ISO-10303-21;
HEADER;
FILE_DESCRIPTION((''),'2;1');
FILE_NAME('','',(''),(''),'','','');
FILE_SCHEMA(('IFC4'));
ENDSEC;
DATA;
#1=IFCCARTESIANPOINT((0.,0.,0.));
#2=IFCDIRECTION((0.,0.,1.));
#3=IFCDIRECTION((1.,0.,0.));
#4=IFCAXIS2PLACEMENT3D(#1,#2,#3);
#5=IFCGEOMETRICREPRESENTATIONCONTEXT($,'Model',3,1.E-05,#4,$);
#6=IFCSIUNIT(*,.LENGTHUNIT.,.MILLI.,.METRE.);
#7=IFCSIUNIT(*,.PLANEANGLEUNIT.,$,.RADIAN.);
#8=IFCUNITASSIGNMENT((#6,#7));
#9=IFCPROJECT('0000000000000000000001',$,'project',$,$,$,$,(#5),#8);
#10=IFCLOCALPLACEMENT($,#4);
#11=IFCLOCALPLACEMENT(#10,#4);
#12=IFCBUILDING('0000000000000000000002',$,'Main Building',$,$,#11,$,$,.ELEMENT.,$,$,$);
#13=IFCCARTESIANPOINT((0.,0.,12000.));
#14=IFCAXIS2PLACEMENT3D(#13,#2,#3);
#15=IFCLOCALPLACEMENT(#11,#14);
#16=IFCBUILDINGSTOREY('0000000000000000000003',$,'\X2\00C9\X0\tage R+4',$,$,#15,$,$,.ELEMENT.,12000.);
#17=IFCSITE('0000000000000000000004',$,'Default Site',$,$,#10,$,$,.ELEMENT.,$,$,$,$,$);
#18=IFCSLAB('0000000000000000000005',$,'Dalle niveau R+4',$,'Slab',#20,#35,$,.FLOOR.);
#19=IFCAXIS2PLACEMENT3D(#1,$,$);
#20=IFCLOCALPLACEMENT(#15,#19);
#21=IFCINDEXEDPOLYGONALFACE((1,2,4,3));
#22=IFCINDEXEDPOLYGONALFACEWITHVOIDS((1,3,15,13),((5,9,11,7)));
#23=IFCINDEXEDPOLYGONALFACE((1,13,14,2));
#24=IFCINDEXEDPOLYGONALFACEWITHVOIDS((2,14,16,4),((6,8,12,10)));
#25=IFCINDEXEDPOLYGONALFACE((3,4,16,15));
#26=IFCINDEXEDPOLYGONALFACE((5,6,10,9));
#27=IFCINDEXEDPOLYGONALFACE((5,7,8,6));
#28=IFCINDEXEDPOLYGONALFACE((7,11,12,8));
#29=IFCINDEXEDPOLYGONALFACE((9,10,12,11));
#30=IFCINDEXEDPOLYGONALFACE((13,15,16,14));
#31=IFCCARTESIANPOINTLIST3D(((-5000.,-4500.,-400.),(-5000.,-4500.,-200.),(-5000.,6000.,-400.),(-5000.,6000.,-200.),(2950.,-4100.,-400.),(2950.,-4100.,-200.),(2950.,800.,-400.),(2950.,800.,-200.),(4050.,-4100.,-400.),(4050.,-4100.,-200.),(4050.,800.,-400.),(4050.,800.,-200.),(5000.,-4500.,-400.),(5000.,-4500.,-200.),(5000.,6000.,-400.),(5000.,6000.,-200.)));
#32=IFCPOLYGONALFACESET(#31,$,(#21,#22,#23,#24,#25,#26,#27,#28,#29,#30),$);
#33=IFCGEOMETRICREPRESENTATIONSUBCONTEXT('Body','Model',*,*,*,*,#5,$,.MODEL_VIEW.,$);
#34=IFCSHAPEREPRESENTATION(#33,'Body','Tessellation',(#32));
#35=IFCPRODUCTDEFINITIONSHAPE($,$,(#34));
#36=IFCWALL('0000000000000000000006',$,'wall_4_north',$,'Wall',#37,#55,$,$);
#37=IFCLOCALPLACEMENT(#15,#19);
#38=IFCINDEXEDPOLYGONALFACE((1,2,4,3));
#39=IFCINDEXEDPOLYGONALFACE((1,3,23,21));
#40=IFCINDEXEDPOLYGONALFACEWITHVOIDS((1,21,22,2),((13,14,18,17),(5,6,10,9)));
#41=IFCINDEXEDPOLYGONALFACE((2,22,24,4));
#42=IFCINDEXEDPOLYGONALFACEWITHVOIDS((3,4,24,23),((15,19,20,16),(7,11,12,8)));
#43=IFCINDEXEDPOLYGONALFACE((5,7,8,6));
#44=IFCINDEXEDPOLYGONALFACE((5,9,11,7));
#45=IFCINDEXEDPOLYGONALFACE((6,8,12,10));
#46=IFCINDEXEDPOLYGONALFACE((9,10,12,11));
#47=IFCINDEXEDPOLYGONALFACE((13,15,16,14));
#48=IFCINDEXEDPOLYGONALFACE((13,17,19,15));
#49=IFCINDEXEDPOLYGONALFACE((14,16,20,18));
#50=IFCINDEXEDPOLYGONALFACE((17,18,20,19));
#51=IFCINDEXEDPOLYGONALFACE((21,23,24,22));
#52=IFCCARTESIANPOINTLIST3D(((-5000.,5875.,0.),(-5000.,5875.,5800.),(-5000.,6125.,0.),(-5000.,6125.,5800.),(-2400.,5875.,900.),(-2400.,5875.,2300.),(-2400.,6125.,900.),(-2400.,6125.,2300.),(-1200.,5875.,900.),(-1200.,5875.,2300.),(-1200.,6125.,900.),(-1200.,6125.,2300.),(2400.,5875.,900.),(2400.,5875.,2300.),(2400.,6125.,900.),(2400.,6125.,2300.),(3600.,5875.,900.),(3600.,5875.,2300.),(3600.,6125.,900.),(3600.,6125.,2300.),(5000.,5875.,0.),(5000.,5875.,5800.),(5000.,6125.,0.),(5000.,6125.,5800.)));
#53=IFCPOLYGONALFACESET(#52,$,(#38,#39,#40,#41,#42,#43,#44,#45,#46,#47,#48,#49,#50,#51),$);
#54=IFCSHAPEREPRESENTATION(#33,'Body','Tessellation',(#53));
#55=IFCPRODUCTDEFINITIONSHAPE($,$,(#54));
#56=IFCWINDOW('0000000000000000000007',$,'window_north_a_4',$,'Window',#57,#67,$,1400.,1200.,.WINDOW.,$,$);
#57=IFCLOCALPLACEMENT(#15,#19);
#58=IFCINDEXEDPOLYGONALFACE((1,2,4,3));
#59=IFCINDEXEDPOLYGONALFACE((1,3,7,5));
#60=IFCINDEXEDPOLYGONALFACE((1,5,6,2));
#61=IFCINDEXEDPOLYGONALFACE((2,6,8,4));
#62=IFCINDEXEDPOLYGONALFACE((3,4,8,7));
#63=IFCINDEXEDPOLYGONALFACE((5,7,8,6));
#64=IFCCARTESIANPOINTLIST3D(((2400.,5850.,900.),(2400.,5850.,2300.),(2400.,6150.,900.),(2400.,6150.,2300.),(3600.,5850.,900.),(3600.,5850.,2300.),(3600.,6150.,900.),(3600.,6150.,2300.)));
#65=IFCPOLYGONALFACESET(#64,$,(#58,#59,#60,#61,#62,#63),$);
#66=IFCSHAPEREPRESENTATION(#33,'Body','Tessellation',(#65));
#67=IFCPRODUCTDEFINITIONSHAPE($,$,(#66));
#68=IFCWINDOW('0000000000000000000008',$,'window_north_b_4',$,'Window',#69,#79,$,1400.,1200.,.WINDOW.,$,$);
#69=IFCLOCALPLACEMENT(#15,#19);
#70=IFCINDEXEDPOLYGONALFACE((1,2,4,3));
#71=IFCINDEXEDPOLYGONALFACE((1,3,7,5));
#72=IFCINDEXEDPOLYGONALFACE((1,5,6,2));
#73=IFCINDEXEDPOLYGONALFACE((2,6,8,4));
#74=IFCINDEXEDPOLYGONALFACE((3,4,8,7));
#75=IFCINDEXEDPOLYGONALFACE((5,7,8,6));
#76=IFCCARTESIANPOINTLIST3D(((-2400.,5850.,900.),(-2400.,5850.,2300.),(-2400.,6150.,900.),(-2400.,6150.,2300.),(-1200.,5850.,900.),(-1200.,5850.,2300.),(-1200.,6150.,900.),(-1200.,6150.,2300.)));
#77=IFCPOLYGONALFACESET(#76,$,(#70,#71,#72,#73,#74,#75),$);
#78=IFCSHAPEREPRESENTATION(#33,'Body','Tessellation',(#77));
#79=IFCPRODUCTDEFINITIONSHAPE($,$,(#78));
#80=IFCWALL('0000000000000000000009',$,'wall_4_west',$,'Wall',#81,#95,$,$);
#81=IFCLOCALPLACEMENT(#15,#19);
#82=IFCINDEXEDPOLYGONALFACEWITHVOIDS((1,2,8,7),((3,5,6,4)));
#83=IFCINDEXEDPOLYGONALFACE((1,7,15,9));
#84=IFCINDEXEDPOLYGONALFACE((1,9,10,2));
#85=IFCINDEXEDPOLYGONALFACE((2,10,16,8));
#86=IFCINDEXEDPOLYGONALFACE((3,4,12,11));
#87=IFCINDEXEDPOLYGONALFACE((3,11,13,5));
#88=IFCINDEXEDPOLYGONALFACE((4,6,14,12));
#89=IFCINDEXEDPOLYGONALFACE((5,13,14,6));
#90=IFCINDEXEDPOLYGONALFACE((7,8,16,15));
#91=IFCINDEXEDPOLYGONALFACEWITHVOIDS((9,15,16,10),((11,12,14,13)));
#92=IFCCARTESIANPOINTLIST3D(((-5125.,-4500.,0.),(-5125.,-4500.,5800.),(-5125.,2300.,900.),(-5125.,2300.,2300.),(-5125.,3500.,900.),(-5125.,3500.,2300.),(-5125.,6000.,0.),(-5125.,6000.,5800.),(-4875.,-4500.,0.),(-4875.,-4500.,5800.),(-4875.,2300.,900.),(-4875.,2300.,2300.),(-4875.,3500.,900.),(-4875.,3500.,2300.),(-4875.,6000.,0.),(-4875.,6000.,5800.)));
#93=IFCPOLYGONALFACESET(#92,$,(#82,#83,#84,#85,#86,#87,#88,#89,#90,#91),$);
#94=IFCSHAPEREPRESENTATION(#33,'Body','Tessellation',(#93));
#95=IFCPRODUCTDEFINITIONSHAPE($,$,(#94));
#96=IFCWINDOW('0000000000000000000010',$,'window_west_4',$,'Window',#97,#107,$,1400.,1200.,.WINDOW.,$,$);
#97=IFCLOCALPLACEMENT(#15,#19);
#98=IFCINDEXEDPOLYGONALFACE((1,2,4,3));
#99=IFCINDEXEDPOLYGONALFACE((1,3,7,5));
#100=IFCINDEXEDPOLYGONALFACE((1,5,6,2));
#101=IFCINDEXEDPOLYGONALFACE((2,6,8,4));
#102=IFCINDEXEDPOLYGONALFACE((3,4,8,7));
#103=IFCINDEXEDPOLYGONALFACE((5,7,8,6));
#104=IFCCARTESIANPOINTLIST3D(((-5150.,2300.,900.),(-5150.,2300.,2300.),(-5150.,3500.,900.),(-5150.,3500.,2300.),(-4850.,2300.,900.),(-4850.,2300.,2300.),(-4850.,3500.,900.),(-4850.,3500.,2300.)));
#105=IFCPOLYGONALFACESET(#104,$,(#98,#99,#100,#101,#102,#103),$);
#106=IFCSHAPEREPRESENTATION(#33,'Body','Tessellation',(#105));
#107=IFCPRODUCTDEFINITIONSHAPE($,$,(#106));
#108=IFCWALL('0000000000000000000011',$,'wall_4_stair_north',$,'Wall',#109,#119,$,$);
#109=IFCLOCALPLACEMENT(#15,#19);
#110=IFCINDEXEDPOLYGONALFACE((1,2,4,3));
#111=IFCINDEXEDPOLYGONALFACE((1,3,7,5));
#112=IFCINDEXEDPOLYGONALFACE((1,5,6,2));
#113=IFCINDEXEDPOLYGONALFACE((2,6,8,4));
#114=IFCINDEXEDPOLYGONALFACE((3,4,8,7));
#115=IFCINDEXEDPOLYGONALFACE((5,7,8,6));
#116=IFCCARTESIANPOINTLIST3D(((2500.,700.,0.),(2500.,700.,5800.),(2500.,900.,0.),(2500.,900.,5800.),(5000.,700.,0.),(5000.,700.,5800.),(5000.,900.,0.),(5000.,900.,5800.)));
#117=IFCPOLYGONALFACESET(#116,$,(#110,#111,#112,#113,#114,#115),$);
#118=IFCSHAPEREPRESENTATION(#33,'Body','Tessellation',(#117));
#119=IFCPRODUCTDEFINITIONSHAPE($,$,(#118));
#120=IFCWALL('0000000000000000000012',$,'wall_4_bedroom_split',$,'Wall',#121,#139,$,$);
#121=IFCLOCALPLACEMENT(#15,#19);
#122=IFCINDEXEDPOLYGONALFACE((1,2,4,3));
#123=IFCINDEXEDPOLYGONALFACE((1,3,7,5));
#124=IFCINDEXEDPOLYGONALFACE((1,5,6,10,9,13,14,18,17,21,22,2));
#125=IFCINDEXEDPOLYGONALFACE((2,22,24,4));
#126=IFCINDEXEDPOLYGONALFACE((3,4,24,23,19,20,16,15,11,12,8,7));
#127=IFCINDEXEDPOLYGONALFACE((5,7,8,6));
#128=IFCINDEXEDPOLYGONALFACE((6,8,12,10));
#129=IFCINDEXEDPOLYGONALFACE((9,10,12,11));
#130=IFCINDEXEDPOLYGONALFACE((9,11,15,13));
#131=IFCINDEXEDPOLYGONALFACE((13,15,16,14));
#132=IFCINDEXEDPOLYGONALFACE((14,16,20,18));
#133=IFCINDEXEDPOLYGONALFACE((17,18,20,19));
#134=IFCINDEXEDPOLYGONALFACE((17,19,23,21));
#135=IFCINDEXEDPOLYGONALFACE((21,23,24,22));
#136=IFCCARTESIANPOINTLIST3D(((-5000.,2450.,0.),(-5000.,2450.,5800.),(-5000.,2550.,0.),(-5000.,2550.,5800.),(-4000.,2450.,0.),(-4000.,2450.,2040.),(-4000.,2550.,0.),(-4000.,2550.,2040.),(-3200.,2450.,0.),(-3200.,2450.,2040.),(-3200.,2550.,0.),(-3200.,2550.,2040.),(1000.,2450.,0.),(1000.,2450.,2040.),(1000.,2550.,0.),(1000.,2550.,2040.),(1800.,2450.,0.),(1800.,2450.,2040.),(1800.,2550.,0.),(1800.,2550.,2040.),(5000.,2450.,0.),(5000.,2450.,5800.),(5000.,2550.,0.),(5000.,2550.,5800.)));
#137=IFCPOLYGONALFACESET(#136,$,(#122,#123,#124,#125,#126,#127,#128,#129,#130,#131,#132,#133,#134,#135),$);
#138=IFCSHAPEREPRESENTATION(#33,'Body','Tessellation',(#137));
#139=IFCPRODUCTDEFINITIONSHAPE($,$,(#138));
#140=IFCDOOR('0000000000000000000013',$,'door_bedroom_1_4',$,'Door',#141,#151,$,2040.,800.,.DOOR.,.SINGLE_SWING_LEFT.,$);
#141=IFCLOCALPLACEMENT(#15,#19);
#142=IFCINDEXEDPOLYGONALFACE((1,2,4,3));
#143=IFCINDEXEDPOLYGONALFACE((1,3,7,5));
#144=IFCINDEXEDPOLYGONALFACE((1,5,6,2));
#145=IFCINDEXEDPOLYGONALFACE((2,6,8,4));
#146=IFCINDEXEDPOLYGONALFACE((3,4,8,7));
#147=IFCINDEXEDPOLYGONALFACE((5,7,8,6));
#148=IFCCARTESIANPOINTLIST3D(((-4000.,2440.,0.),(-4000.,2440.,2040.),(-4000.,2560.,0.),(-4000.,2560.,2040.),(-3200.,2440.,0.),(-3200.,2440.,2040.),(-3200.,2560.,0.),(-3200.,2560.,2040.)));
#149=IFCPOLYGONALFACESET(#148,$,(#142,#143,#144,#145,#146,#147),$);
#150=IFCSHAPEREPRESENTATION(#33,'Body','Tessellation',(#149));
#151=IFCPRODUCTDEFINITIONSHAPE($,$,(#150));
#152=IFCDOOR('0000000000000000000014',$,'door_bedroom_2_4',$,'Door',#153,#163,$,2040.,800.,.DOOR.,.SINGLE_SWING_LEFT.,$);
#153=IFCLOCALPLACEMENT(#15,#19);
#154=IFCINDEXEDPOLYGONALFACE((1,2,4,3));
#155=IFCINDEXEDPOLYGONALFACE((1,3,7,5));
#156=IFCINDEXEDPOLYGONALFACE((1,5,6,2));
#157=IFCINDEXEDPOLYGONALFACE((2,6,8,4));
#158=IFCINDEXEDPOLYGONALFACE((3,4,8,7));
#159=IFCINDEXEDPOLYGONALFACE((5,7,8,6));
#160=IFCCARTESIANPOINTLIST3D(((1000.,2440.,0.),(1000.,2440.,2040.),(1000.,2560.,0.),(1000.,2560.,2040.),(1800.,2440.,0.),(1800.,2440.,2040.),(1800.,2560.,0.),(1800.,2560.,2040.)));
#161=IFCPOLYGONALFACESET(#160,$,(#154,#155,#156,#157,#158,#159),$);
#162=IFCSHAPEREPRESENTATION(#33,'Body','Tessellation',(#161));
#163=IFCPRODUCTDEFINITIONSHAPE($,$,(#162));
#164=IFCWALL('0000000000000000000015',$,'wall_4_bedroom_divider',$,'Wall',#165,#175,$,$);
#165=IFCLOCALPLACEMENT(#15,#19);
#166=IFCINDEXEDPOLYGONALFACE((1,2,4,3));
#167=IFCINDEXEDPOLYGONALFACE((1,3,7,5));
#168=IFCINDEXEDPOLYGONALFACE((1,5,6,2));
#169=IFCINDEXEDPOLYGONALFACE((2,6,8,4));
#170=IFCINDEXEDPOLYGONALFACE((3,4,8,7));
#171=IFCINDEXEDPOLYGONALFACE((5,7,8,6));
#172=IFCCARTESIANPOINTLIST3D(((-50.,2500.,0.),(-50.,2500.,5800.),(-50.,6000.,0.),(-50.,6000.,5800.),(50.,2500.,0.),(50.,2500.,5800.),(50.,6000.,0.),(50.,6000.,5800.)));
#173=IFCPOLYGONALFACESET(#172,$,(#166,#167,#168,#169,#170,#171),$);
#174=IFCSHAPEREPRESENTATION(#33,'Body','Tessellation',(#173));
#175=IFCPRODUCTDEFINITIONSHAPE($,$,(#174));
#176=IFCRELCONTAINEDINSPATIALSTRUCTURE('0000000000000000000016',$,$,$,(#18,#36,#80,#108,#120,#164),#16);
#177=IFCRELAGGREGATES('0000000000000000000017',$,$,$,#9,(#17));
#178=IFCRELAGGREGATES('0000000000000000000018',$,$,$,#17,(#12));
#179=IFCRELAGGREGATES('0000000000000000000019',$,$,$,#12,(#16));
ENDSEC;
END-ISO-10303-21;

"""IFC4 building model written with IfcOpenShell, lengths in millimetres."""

from ifc_helpers import new_model, si_unit, frame, origin_with_axes, place, context, subcontext, project, spatial, polyline, outline, extrude, element, fill, save


model = new_model("IFC4")

# Units and contexts
model_context = context("Model", 3, precision=1e-05, world=origin_with_axes())
body_context = subcontext(model_context, "Body", "Model", "MODEL_VIEW")
ifc_project = project(units=[si_unit("LENGTHUNIT", "METRE", prefix="MILLI"), si_unit("PLANEANGLEUNIT", "RADIAN")], contexts=[model_context])

# Site, building, storey
site_placement = place(None, origin_with_axes())
site = spatial("IfcSite", under=ifc_project, at=site_placement, Name="Default Site", CompositionType="ELEMENT")
building_placement = place(site_placement, origin_with_axes())
building = spatial("IfcBuilding", under=site, at=building_placement, Name="Main Building", CompositionType="ELEMENT")
storey_placement = place(building_placement, frame((0.0, 0.0, 12000.0), z_axis=(0.0, 0.0, 1.0), x_axis=(1.0, 0.0, 0.0)))
storey = spatial("IfcBuildingStorey", under=building, at=storey_placement, Name="Étage R+4", CompositionType="ELEMENT", Elevation=12000.0)

# Slab
slab_placement = place(storey_placement, frame((0.0, 0.0, -400.0), z_axis=(0.0, 0.0, 1.0), x_axis=(1.0, 0.0, 0.0)))
element("IfcSlab", 1, at=slab_placement, inside=storey, Name="Dalle niveau R+4", ObjectType="Slab", PredefinedType="FLOOR", context=body_context, shape_type="SweptSolid", body=[
    extrude(outline(polyline([(-5000.0, -4500.0), (5000.0, -4500.0), (5000.0, 6000.0), (-5000.0, 6000.0), (-5000.0, -4500.0)]), holes=[polyline([(2950.0, -4100.0), (2950.0, 800.0), (4050.0, 800.0), (4050.0, -4100.0), (2950.0, -4100.0)])]), origin_with_axes(), (0.0, 0.0, 1.0), 200.0),
])

# Wall, openings, windows
wall_1_placement = place(storey_placement, frame((5000.0, 6000.0, 0.0), z_axis=(0.0, 0.0, 1.0), x_axis=(-1.0, 0.0, 0.0)))
wall_1 = element("IfcWall", 2, at=wall_1_placement, inside=storey, Name="wall_4_north", ObjectType="Wall", context=body_context, shape_type="SweptSolid", body=[
    extrude(outline(polyline([(0.0, -125.0), (10000.0, -125.0), (10000.0, 125.0), (0.0, 125.0), (0.0, -125.0)])), origin_with_axes(), (0.0, 0.0, 1.0), 5800.0),
])
placement_1 = place(wall_1_placement, frame((1400.0, 0.0, 900.0), z_axis=(0.0, 0.0, 1.0), x_axis=(1.0, 0.0, 0.0)))
opening_1 = element("IfcOpeningElement", 3, at=placement_1, cuts=wall_1, PredefinedType="OPENING", context=body_context, shape_type="SweptSolid", body=[
    extrude(outline(polyline([(0.0, -150.0), (1200.0, -150.0), (1200.0, 150.0), (0.0, 150.0), (0.0, -150.0)])), origin_with_axes(), (0.0, 0.0, 1.0), 1400.0),
])
placement_2 = place(wall_1_placement, frame((6200.0, 0.0, 900.0), z_axis=(0.0, 0.0, 1.0), x_axis=(1.0, 0.0, 0.0)))
opening_2 = element("IfcOpeningElement", 4, at=placement_2, cuts=wall_1, PredefinedType="OPENING", context=body_context, shape_type="SweptSolid", body=[
    extrude(outline(polyline([(0.0, -150.0), (1200.0, -150.0), (1200.0, 150.0), (0.0, 150.0), (0.0, -150.0)])), origin_with_axes(), (0.0, 0.0, 1.0), 1400.0),
])
window_1 = element("IfcWindow", 5, at=placement_1, Name="window_north_a_4", ObjectType="Window", OverallHeight=1400.0, OverallWidth=1200.0, PredefinedType="WINDOW", context=body_context, shape_type="SweptSolid", body=[
    extrude(outline(polyline([(0.0, -150.0), (1200.0, -150.0), (1200.0, 150.0), (0.0, 150.0), (0.0, -150.0)])), origin_with_axes(), (0.0, 0.0, 1.0), 1400.0),
])
fill(opening_1, window_1)
window_2 = element("IfcWindow", 6, at=placement_2, Name="window_north_b_4", ObjectType="Window", OverallHeight=1400.0, OverallWidth=1200.0, PredefinedType="WINDOW", context=body_context, shape_type="SweptSolid", body=[
    extrude(outline(polyline([(0.0, -150.0), (1200.0, -150.0), (1200.0, 150.0), (0.0, 150.0), (0.0, -150.0)])), origin_with_axes(), (0.0, 0.0, 1.0), 1400.0),
])
fill(opening_2, window_2)

# Wall, opening, window
wall_2_placement = place(storey_placement, frame((-5000.0, 6000.0, 0.0), z_axis=(0.0, 0.0, 1.0), x_axis=(0.0, -1.0, 0.0)))
wall_2 = element("IfcWall", 7, at=wall_2_placement, inside=storey, Name="wall_4_west", ObjectType="Wall", context=body_context, shape_type="SweptSolid", body=[
    extrude(outline(polyline([(0.0, -125.0), (10500.0, -125.0), (10500.0, 125.0), (0.0, 125.0), (0.0, -125.0)])), origin_with_axes(), (0.0, 0.0, 1.0), 5800.0),
])
placement_3 = place(wall_2_placement, frame((2500.0, 0.0, 900.0), z_axis=(0.0, 0.0, 1.0), x_axis=(1.0, 0.0, 0.0)))
opening_3 = element("IfcOpeningElement", 8, at=placement_3, cuts=wall_2, PredefinedType="OPENING", context=body_context, shape_type="SweptSolid", body=[
    extrude(outline(polyline([(0.0, -150.0), (1200.0, -150.0), (1200.0, 150.0), (0.0, 150.0), (0.0, -150.0)])), origin_with_axes(), (0.0, 0.0, 1.0), 1400.0),
])
window_3 = element("IfcWindow", 9, at=placement_3, Name="window_west_4", ObjectType="Window", OverallHeight=1400.0, OverallWidth=1200.0, PredefinedType="WINDOW", context=body_context, shape_type="SweptSolid", body=[
    extrude(outline(polyline([(0.0, -150.0), (1200.0, -150.0), (1200.0, 150.0), (0.0, 150.0), (0.0, -150.0)])), origin_with_axes(), (0.0, 0.0, 1.0), 1400.0),
])
fill(opening_3, window_3)

# Wall
wall_3_placement = place(storey_placement, frame((2500.0, 800.0, 0.0), z_axis=(0.0, 0.0, 1.0), x_axis=(1.0, 0.0, 0.0)))
element("IfcWall", 10, at=wall_3_placement, inside=storey, Name="wall_4_stair_north", ObjectType="Wall", context=body_context, shape_type="SweptSolid", body=[
    extrude(outline(polyline([(0.0, -100.0), (2500.0, -100.0), (2500.0, 100.0), (0.0, 100.0), (0.0, -100.0)])), origin_with_axes(), (0.0, 0.0, 1.0), 5800.0),
])

# Wall, openings, doors
wall_4_placement = place(storey_placement, frame((-5000.0, 2500.0, 0.0), z_axis=(0.0, 0.0, 1.0), x_axis=(1.0, 0.0, 0.0)))
wall_4 = element("IfcWall", 11, at=wall_4_placement, inside=storey, Name="wall_4_bedroom_split", ObjectType="Wall", context=body_context, shape_type="SweptSolid", body=[
    extrude(outline(polyline([(0.0, -50.0), (10000.0, -50.0), (10000.0, 50.0), (0.0, 50.0), (0.0, -50.0)])), origin_with_axes(), (0.0, 0.0, 1.0), 5800.0),
])
placement_4 = place(wall_4_placement, frame((1000.0, 0.0, 0.0), z_axis=(0.0, 0.0, 1.0), x_axis=(1.0, 0.0, 0.0)))
opening_4 = element("IfcOpeningElement", 12, at=placement_4, cuts=wall_4, PredefinedType="OPENING", context=body_context, shape_type="SweptSolid", body=[
    extrude(outline(polyline([(0.0, -60.0), (800.0, -60.0), (800.0, 60.0), (0.0, 60.0), (0.0, -60.0)])), origin_with_axes(), (0.0, 0.0, 1.0), 2040.0),
])
placement_5 = place(wall_4_placement, frame((6000.0, 0.0, 0.0), z_axis=(0.0, 0.0, 1.0), x_axis=(1.0, 0.0, 0.0)))
opening_5 = element("IfcOpeningElement", 13, at=placement_5, cuts=wall_4, PredefinedType="OPENING", context=body_context, shape_type="SweptSolid", body=[
    extrude(outline(polyline([(0.0, -60.0), (800.0, -60.0), (800.0, 60.0), (0.0, 60.0), (0.0, -60.0)])), origin_with_axes(), (0.0, 0.0, 1.0), 2040.0),
])
door_1 = element("IfcDoor", 14, at=placement_4, Name="door_bedroom_1_4", ObjectType="Door", OperationType="SINGLE_SWING_LEFT", OverallHeight=2040.0, OverallWidth=800.0, PredefinedType="DOOR", context=body_context, shape_type="SweptSolid", body=[
    extrude(outline(polyline([(0.0, -60.0), (800.0, -60.0), (800.0, 60.0), (0.0, 60.0), (0.0, -60.0)])), origin_with_axes(), (0.0, 0.0, 1.0), 2040.0),
])
fill(opening_4, door_1)
door_2 = element("IfcDoor", 15, at=placement_5, Name="door_bedroom_2_4", ObjectType="Door", OperationType="SINGLE_SWING_LEFT", OverallHeight=2040.0, OverallWidth=800.0, PredefinedType="DOOR", context=body_context, shape_type="SweptSolid", body=[
    extrude(outline(polyline([(0.0, -60.0), (800.0, -60.0), (800.0, 60.0), (0.0, 60.0), (0.0, -60.0)])), origin_with_axes(), (0.0, 0.0, 1.0), 2040.0),
])
fill(opening_5, door_2)

# Wall
wall_5_placement = place(storey_placement, frame((0.0, 2500.0, 0.0), z_axis=(0.0, 0.0, 1.0), x_axis=(0.0, 1.0, 0.0)))
element("IfcWall", 16, at=wall_5_placement, inside=storey, Name="wall_4_bedroom_divider", ObjectType="Wall", context=body_context, shape_type="SweptSolid", body=[
    extrude(outline(polyline([(0.0, -50.0), (3500.0, -50.0), (3500.0, 50.0), (0.0, 50.0), (0.0, -50.0)])), origin_with_axes(), (0.0, 0.0, 1.0), 5800.0),
])

save(model, "model.ifc")
